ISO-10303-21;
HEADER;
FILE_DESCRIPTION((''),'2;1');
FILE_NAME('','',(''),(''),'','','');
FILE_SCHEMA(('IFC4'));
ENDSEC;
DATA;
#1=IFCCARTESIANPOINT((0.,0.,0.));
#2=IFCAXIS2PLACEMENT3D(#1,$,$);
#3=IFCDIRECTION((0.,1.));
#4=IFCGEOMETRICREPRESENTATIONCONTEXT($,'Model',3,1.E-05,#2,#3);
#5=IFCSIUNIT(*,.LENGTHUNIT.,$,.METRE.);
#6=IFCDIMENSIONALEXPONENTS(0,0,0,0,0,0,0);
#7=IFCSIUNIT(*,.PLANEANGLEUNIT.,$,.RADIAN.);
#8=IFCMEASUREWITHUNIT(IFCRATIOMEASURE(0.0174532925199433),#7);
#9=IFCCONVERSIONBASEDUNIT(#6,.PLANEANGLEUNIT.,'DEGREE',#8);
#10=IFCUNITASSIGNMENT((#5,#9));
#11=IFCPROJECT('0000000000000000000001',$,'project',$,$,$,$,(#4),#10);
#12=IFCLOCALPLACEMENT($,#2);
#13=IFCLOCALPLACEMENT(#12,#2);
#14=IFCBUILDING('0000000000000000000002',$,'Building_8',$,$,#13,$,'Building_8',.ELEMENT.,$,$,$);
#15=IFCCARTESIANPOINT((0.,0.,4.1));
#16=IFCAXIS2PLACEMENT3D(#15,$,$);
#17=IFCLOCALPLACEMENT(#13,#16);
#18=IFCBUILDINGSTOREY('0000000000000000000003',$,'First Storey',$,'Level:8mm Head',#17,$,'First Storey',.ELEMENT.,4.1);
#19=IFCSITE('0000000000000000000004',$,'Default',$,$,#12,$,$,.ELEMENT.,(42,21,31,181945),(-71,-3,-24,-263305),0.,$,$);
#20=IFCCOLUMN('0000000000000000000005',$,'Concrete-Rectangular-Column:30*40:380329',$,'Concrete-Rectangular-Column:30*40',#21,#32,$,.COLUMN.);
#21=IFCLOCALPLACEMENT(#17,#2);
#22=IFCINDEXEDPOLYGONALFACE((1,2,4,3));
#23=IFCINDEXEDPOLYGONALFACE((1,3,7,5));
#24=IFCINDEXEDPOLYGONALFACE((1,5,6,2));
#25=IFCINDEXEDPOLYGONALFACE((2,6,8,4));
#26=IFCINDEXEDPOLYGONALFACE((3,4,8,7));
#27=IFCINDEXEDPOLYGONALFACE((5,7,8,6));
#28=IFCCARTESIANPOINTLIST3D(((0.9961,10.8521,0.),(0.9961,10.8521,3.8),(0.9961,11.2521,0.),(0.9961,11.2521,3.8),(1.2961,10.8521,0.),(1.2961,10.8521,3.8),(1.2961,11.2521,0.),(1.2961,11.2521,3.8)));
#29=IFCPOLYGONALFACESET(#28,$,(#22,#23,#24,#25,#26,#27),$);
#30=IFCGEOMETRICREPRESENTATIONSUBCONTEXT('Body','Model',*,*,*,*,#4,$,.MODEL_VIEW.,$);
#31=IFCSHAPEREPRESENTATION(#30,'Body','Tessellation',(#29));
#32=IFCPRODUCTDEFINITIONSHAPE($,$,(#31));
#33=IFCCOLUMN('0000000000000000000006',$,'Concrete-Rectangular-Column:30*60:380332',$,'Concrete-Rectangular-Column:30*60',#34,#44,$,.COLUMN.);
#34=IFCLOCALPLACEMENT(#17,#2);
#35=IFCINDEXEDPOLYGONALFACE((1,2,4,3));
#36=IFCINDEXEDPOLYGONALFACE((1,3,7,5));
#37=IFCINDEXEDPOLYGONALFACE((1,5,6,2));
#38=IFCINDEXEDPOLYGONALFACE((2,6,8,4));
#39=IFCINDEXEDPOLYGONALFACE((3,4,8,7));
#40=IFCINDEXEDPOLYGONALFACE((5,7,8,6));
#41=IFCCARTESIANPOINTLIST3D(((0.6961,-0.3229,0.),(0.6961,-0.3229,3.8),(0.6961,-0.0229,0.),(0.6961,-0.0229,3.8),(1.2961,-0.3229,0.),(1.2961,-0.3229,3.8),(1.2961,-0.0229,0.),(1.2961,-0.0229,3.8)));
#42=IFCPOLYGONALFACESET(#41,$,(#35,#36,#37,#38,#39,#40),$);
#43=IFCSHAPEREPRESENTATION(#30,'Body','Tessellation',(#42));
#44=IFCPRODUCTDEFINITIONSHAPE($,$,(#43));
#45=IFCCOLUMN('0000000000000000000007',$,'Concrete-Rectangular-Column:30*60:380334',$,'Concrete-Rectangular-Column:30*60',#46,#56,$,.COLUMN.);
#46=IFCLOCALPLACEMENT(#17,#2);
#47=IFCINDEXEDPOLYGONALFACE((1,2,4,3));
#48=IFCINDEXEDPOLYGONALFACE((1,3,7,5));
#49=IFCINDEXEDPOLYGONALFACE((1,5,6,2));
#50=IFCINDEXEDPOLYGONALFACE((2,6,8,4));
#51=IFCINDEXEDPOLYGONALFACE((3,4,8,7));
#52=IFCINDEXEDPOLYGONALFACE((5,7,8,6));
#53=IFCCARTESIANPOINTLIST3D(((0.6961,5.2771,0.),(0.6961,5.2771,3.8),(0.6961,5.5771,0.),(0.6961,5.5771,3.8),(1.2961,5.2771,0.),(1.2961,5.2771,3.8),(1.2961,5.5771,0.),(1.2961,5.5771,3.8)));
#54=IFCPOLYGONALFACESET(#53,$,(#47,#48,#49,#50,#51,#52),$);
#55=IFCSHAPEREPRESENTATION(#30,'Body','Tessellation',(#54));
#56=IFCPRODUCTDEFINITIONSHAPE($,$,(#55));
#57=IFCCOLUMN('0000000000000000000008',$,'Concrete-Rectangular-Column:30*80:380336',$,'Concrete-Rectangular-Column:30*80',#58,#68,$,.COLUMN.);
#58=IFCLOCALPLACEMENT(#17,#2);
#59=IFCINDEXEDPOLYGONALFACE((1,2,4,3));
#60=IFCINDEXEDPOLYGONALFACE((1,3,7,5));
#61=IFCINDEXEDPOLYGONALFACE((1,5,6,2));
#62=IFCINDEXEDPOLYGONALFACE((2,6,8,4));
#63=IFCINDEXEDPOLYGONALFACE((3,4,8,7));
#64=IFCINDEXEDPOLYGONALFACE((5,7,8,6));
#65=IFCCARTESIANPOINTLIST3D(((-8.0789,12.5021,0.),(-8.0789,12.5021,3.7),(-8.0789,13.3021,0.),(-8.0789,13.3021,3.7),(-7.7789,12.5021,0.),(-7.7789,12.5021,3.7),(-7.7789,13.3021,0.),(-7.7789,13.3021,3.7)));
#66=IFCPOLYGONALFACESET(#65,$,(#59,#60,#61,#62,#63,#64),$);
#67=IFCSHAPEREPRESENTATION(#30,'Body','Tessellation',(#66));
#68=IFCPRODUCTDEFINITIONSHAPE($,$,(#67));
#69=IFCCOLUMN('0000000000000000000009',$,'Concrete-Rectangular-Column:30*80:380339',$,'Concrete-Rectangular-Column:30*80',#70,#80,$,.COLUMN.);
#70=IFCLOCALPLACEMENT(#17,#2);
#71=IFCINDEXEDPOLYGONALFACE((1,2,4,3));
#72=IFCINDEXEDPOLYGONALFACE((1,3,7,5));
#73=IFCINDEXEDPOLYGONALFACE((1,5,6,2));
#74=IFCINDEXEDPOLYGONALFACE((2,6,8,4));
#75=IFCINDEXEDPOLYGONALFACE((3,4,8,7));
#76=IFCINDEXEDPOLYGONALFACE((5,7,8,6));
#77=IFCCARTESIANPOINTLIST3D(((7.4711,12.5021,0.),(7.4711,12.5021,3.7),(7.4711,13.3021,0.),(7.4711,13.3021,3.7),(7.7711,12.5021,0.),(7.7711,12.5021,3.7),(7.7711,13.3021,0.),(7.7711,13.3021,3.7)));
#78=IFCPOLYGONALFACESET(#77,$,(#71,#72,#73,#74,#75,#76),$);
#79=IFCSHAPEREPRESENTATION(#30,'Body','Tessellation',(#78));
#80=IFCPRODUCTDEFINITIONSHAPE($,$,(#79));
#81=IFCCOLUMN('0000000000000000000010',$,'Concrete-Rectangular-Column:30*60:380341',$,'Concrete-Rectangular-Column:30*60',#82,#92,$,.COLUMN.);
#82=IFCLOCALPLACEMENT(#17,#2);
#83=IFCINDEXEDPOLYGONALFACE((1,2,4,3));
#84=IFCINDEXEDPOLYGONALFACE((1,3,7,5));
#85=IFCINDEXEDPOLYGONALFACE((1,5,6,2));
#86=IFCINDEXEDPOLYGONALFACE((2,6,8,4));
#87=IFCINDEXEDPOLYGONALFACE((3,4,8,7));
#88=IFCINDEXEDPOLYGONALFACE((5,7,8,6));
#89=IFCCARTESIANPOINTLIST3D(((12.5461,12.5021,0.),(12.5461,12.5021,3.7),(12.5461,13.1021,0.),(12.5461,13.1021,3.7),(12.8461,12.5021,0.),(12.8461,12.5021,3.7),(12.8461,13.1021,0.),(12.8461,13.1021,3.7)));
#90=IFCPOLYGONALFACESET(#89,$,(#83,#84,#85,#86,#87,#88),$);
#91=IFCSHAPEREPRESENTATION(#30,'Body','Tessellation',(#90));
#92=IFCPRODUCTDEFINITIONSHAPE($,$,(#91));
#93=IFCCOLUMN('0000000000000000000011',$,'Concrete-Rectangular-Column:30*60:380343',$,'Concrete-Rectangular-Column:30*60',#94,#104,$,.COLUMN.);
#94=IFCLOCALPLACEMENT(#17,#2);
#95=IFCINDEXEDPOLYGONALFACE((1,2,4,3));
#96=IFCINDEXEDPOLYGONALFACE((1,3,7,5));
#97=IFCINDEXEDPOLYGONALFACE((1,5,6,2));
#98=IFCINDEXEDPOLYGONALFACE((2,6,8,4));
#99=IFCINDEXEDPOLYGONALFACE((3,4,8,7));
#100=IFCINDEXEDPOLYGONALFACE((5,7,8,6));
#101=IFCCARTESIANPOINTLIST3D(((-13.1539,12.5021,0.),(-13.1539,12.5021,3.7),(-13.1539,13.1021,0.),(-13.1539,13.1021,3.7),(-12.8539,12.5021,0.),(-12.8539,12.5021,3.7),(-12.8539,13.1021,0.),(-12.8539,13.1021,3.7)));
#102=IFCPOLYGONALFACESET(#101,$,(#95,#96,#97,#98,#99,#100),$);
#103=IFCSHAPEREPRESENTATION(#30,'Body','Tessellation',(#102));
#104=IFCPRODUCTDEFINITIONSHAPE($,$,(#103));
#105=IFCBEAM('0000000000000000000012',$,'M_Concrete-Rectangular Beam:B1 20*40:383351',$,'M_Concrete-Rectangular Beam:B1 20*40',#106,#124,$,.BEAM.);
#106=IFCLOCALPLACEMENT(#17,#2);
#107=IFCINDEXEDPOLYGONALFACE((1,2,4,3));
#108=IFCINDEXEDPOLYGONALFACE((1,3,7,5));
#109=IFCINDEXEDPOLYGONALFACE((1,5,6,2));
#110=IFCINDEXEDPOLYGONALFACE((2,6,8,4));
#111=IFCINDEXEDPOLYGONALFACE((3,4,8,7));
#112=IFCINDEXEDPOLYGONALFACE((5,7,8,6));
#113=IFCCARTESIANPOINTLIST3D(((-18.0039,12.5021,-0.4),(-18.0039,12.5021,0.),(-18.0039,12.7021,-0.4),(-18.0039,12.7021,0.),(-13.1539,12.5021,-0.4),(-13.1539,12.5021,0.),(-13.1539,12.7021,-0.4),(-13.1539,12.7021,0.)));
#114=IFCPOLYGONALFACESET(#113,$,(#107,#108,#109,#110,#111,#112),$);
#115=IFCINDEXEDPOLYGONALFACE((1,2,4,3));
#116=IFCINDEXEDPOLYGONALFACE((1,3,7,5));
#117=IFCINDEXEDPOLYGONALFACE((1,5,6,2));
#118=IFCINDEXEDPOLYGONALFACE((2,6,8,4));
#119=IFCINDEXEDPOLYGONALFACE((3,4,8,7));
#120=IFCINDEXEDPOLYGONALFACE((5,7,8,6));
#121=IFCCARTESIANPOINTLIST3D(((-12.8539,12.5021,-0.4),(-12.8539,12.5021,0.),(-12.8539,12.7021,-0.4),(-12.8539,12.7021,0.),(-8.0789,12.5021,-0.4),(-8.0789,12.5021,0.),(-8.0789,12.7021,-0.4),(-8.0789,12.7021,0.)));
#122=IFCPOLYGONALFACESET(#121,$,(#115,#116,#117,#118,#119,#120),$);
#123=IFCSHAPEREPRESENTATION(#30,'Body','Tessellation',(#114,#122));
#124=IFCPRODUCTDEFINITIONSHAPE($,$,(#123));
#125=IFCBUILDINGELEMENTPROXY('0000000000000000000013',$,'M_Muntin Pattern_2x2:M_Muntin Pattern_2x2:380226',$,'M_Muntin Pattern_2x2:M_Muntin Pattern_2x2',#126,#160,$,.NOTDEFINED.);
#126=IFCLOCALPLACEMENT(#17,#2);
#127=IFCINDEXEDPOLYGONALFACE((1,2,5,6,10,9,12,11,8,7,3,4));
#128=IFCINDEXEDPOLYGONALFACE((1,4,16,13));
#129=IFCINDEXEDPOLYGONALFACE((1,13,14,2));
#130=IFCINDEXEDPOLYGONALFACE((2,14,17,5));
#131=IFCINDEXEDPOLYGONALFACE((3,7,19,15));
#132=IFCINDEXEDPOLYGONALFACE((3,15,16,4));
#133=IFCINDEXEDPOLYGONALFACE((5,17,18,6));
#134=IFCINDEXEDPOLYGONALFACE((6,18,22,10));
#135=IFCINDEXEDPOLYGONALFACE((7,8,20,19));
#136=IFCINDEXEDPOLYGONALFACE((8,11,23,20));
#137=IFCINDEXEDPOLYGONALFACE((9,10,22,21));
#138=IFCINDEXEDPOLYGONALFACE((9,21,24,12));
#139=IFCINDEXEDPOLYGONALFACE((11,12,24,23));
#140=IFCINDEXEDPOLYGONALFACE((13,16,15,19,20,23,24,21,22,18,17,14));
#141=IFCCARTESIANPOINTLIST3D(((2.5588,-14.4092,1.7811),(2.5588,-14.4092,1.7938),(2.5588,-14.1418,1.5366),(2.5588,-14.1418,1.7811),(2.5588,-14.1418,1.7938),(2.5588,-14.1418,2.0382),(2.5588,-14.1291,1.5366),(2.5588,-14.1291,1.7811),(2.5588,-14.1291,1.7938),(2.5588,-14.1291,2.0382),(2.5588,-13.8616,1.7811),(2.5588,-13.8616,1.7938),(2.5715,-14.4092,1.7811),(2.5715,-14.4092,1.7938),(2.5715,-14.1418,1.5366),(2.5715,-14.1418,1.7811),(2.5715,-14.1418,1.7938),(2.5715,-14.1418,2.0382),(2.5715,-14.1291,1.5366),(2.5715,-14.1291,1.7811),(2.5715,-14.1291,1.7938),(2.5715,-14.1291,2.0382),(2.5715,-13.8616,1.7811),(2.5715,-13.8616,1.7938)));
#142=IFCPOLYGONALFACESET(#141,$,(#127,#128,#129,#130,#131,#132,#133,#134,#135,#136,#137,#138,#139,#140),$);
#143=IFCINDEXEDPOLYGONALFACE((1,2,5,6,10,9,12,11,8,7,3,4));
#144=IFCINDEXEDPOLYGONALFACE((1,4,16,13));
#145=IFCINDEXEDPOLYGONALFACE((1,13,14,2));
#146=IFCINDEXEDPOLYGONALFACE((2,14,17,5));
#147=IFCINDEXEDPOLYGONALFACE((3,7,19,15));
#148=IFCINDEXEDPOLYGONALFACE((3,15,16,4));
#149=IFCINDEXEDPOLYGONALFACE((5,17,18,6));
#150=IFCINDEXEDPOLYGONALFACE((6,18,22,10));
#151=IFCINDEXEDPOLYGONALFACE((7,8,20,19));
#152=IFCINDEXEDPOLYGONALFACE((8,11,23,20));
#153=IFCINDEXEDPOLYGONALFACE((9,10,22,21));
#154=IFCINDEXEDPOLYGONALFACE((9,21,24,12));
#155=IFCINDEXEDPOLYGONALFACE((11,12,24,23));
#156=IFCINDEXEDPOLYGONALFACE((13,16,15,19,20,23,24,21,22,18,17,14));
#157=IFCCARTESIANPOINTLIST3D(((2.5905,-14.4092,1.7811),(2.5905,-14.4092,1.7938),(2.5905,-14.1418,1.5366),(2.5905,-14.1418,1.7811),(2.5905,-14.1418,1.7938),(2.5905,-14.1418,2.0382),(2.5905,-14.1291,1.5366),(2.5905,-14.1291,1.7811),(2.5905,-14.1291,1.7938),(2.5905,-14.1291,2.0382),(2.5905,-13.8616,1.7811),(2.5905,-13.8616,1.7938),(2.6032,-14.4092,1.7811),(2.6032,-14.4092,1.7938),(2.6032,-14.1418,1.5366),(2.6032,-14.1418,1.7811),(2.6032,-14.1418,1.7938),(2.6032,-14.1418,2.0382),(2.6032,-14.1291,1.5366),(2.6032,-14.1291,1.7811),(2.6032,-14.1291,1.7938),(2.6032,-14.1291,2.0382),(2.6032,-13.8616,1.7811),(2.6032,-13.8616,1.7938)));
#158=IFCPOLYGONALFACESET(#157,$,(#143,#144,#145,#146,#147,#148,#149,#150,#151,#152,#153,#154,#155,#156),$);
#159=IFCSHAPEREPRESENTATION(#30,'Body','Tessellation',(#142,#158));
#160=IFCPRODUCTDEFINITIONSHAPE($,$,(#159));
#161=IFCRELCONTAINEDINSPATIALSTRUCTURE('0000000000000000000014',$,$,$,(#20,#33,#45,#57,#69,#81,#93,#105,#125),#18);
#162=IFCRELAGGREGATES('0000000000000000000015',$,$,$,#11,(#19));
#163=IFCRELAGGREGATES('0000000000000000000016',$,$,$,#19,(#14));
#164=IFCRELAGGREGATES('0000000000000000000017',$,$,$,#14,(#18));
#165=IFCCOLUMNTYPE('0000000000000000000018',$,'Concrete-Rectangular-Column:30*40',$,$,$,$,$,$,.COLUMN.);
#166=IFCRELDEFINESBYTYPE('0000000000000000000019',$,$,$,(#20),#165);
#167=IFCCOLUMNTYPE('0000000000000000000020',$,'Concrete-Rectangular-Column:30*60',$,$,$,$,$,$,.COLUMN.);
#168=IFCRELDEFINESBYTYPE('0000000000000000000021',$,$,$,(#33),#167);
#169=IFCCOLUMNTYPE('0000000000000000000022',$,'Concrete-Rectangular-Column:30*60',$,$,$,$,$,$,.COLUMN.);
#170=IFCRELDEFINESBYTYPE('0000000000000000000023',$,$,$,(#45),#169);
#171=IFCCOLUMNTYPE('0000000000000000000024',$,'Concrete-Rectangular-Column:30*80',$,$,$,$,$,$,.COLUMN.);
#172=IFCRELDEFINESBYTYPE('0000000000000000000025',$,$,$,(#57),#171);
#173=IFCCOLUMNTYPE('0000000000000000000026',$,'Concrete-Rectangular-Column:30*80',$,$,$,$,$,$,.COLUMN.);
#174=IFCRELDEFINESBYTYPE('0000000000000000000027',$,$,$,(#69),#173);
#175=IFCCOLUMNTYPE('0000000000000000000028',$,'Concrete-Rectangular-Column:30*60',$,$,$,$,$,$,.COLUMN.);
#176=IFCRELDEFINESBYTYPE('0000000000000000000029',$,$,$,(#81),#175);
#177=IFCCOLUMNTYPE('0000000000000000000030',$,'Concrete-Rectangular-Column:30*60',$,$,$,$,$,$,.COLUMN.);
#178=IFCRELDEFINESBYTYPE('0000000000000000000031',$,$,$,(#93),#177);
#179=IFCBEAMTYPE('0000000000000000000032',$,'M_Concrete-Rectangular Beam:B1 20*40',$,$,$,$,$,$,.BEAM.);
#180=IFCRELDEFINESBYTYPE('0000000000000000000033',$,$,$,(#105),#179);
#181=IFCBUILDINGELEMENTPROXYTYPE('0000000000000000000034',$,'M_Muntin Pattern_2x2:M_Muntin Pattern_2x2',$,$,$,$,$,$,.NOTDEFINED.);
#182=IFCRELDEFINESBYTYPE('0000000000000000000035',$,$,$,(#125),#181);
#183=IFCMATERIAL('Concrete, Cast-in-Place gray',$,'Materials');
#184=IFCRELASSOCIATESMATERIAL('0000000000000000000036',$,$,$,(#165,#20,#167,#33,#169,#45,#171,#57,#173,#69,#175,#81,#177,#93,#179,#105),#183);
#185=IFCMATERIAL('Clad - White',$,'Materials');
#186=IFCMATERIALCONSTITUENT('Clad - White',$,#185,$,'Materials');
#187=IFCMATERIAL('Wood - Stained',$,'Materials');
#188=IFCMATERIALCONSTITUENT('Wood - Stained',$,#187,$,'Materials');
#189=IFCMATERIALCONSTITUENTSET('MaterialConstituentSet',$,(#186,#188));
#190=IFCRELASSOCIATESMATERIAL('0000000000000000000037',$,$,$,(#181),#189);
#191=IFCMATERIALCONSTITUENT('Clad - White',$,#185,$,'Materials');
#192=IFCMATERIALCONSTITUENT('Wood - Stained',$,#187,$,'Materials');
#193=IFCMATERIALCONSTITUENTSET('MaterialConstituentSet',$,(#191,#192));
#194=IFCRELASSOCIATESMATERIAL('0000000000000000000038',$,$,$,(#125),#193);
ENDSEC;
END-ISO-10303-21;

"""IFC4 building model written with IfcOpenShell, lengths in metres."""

from ifc_helpers import new_model, entity, si_unit, converted_unit, direction, frame, origin, place, context, subcontext, project, spatial, indexed_curve, outline, extrude, source, transform, mapped, material, constituent, constituent_set, type_object, type_shapes, element, save


model = new_model("IFC4")

# Units and contexts
model_context = context("Model", 3, precision=1e-05, world=origin(), true_north=direction((0.0, 1.0)))
body_context = subcontext(model_context, "Body", "Model", "MODEL_VIEW")
ifc_project = project(units=[si_unit("LENGTHUNIT", "METRE"), converted_unit("PLANEANGLEUNIT", "DEGREE", entity("IfcRatioMeasure", 0.0174532925199433), si_unit("PLANEANGLEUNIT", "RADIAN"), dimensions=[0, 0, 0, 0, 0, 0, 0])], contexts=[model_context])

# Site, building, storey
site_placement = place(None, origin())
site = spatial("IfcSite", under=ifc_project, at=site_placement, Name="Default", CompositionType="ELEMENT", RefLatitude=(42, 21, 31, 181945), RefLongitude=(-71, -3, -24, -263305), RefElevation=0.0)
building_placement = place(site_placement, origin())
building = spatial("IfcBuilding", under=site, at=building_placement, Name="Building_8", LongName="Building_8", CompositionType="ELEMENT")
storey_placement = place(building_placement, frame((0.0, 0.0, 4.1)))
storey = spatial("IfcBuildingStorey", under=building, at=storey_placement, Name="First Storey", ObjectType="Level:8mm Head", LongName="First Storey", CompositionType="ELEMENT", Elevation=4.1)

# Columns
ifc_material_1 = material(Name="Concrete, Cast-in-Place gray", Category="Materials")
column_type_1 = type_object("IfcColumnType", Name="Concrete-Rectangular-Column:30*40", PredefinedType="COLUMN", material=ifc_material_1)
shared_shape_1 = source(origin(), body_context, "Body", "SweptSolid", [
    extrude(outline(indexed_curve([(-0.2, -0.15), (0.2, -0.15), (0.2, 0.15), (-0.2, 0.15), (-0.2, -0.15)], self_intersect=False)), frame((1.1461, 11.0521, 4.1), z_axis=(0.0, 0.0, 1.0), x_axis=(0.0, -1.0, 0.0)), (0.0, 0.0, 1.0), 3.8),
])
type_shapes(column_type_1, [shared_shape_1])
column_1_placement = place(storey_placement, frame((0.0, 0.0, -4.1)))
element("IfcColumn", 1, at=column_1_placement, inside=storey, type_object=column_type_1, material=ifc_material_1, Name="Concrete-Rectangular-Column:30*40:380329", ObjectType="Concrete-Rectangular-Column:30*40", PredefinedType="COLUMN", context=body_context, shape_type="MappedRepresentation", body=[
    mapped(shared_shape_1, transform((0.0, 0.0, 0.0), scale=1.0)),
])
column_type_2 = type_object("IfcColumnType", Name="Concrete-Rectangular-Column:30*60", PredefinedType="COLUMN", material=ifc_material_1)
shared_shape_2 = source(origin(), body_context, "Body", "SweptSolid", [
    extrude(outline(indexed_curve([(-0.15, -0.3), (0.15, -0.3), (0.15, 0.3), (-0.15, 0.3), (-0.15, -0.3)], self_intersect=False)), frame((0.9961, -0.1729, 4.1), z_axis=(0.0, 0.0, 1.0), x_axis=(0.0, -1.0, 0.0)), (0.0, 0.0, 1.0), 3.8),
])
type_shapes(column_type_2, [shared_shape_2])
column_2_placement = place(storey_placement, frame((0.0, 0.0, -4.1)))
element("IfcColumn", 2, at=column_2_placement, inside=storey, type_object=column_type_2, material=ifc_material_1, Name="Concrete-Rectangular-Column:30*60:380332", ObjectType="Concrete-Rectangular-Column:30*60", PredefinedType="COLUMN", context=body_context, shape_type="MappedRepresentation", body=[
    mapped(shared_shape_2, transform((0.0, 0.0, 0.0), scale=1.0)),
])
column_type_3 = type_object("IfcColumnType", Name="Concrete-Rectangular-Column:30*60", PredefinedType="COLUMN", material=ifc_material_1)
shared_shape_3 = source(origin(), body_context, "Body", "SweptSolid", [
    extrude(outline(indexed_curve([(-0.15, -0.3), (0.15, -0.3), (0.15, 0.3), (-0.15, 0.3), (-0.15, -0.3)], self_intersect=False)), frame((0.9961, 5.4271, 4.1), z_axis=(0.0, 0.0, 1.0), x_axis=(0.0, -1.0, 0.0)), (0.0, 0.0, 1.0), 3.8),
])
type_shapes(column_type_3, [shared_shape_3])
column_3_placement = place(storey_placement, frame((0.0, 0.0, -4.1)))
element("IfcColumn", 3, at=column_3_placement, inside=storey, type_object=column_type_3, material=ifc_material_1, Name="Concrete-Rectangular-Column:30*60:380334", ObjectType="Concrete-Rectangular-Column:30*60", PredefinedType="COLUMN", context=body_context, shape_type="MappedRepresentation", body=[
    mapped(shared_shape_3, transform((0.0, 0.0, 0.0), scale=1.0)),
])
column_type_4 = type_object("IfcColumnType", Name="Concrete-Rectangular-Column:30*80", PredefinedType="COLUMN", material=ifc_material_1)
shared_shape_4 = source(origin(), body_context, "Body", "SweptSolid", [
    extrude(outline(indexed_curve([(-0.4, -0.15), (0.4, -0.15), (0.4, 0.15), (-0.4, 0.15), (-0.4, -0.15)], self_intersect=False)), frame((-7.9289, 12.9021, 4.1), z_axis=(0.0, 0.0, 1.0), x_axis=(0.0, -1.0, 0.0)), (0.0, 0.0, 1.0), 3.7),
])
type_shapes(column_type_4, [shared_shape_4])
column_4_placement = place(storey_placement, frame((0.0, 0.0, -4.1)))
element("IfcColumn", 4, at=column_4_placement, inside=storey, type_object=column_type_4, material=ifc_material_1, Name="Concrete-Rectangular-Column:30*80:380336", ObjectType="Concrete-Rectangular-Column:30*80", PredefinedType="COLUMN", context=body_context, shape_type="MappedRepresentation", body=[
    mapped(shared_shape_4, transform((0.0, 0.0, 0.0), scale=1.0)),
])
column_type_5 = type_object("IfcColumnType", Name="Concrete-Rectangular-Column:30*80", PredefinedType="COLUMN", material=ifc_material_1)
shared_shape_5 = source(origin(), body_context, "Body", "SweptSolid", [
    extrude(outline(indexed_curve([(-0.4, -0.15), (0.4, -0.15), (0.4, 0.15), (-0.4, 0.15), (-0.4, -0.15)], self_intersect=False)), frame((7.6211, 12.9021, 4.1), z_axis=(0.0, 0.0, 1.0), x_axis=(0.0, -1.0, 0.0)), (0.0, 0.0, 1.0), 3.7),
])
type_shapes(column_type_5, [shared_shape_5])
column_5_placement = place(storey_placement, frame((0.0, 0.0, -4.1)))
element("IfcColumn", 5, at=column_5_placement, inside=storey, type_object=column_type_5, material=ifc_material_1, Name="Concrete-Rectangular-Column:30*80:380339", ObjectType="Concrete-Rectangular-Column:30*80", PredefinedType="COLUMN", context=body_context, shape_type="MappedRepresentation", body=[
    mapped(shared_shape_5, transform((0.0, 0.0, 0.0), scale=1.0)),
])
column_type_6 = type_object("IfcColumnType", Name="Concrete-Rectangular-Column:30*60", PredefinedType="COLUMN", material=ifc_material_1)
shared_shape_6 = source(origin(), body_context, "Body", "SweptSolid", [
    extrude(outline(indexed_curve([(-0.3, -0.15), (0.3, -0.15), (0.3, 0.15), (-0.3, 0.15), (-0.3, -0.15)], self_intersect=False)), frame((12.6961, 12.8021, 4.1), z_axis=(0.0, 0.0, 1.0), x_axis=(0.0, -1.0, 0.0)), (0.0, 0.0, 1.0), 3.7),
])
type_shapes(column_type_6, [shared_shape_6])
column_6_placement = place(storey_placement, frame((0.0, 0.0, -4.1)))
element("IfcColumn", 6, at=column_6_placement, inside=storey, type_object=column_type_6, material=ifc_material_1, Name="Concrete-Rectangular-Column:30*60:380341", ObjectType="Concrete-Rectangular-Column:30*60", PredefinedType="COLUMN", context=body_context, shape_type="MappedRepresentation", body=[
    mapped(shared_shape_6, transform((0.0, 0.0, 0.0), scale=1.0)),
])
column_type_7 = type_object("IfcColumnType", Name="Concrete-Rectangular-Column:30*60", PredefinedType="COLUMN", material=ifc_material_1)
shared_shape_7 = source(origin(), body_context, "Body", "SweptSolid", [
    extrude(outline(indexed_curve([(-0.3, -0.15), (0.3, -0.15), (0.3, 0.15), (-0.3, 0.15), (-0.3, -0.15)], self_intersect=False)), frame((-13.0039, 12.8021, 4.1), z_axis=(0.0, 0.0, 1.0), x_axis=(0.0, -1.0, 0.0)), (0.0, 0.0, 1.0), 3.7),
])
type_shapes(column_type_7, [shared_shape_7])
column_7_placement = place(storey_placement, frame((0.0, 0.0, -4.1)))
element("IfcColumn", 7, at=column_7_placement, inside=storey, type_object=column_type_7, material=ifc_material_1, Name="Concrete-Rectangular-Column:30*60:380343", ObjectType="Concrete-Rectangular-Column:30*60", PredefinedType="COLUMN", context=body_context, shape_type="MappedRepresentation", body=[
    mapped(shared_shape_7, transform((0.0, 0.0, 0.0), scale=1.0)),
])

# Beam
beam_type = type_object("IfcBeamType", Name="M_Concrete-Rectangular Beam:B1 20*40", PredefinedType="BEAM", material=ifc_material_1)
shared_shape_8 = source(origin(), body_context, "Body", "SweptSolid", [
    extrude(outline(indexed_curve([(-0.2, -0.1), (0.2, -0.1), (0.2, 0.1), (-0.2, 0.1), (-0.2, -0.1)], self_intersect=False)), frame((-18.0039, 12.6021, 3.9), z_axis=(1.0, 0.0, 0.0), x_axis=(0.0, 0.0, -1.0)), (0.0, 0.0, 1.0), 4.85),
    extrude(outline(indexed_curve([(-0.2, -0.1), (0.2, -0.1), (0.2, 0.1), (-0.2, 0.1), (-0.2, -0.1)], self_intersect=False)), frame((-12.8539, 12.6021, 3.9), z_axis=(1.0, 0.0, 0.0), x_axis=(0.0, 0.0, -1.0)), (0.0, 0.0, 1.0), 4.775),
])
type_shapes(beam_type, [shared_shape_8])
beam_placement = place(storey_placement, frame((0.0, 0.0, -4.1)))
element("IfcBeam", 8, at=beam_placement, inside=storey, type_object=beam_type, material=ifc_material_1, Name="M_Concrete-Rectangular Beam:B1 20*40:383351", ObjectType="M_Concrete-Rectangular Beam:B1 20*40", PredefinedType="BEAM", context=body_context, shape_type="MappedRepresentation", body=[
    mapped(shared_shape_8, transform((0.0, 0.0, 0.0), scale=1.0)),
])

# Building element proxy
ifc_material_2 = material(Name="Clad - White", Category="Materials")
ifc_constituent_1 = constituent(ifc_material_2, Name="Clad - White", Category="Materials")
ifc_material_3 = material(Name="Wood - Stained", Category="Materials")
ifc_constituent_2 = constituent(ifc_material_3, Name="Wood - Stained", Category="Materials")
ifc_constituent_set_1 = constituent_set(constituents=[ifc_constituent_1, ifc_constituent_2], Name="MaterialConstituentSet")
ifc_constituent_3 = constituent(ifc_material_2, Name="Clad - White", Category="Materials")
ifc_constituent_4 = constituent(ifc_material_3, Name="Wood - Stained", Category="Materials")
ifc_constituent_set_2 = constituent_set(constituents=[ifc_constituent_3, ifc_constituent_4], Name="MaterialConstituentSet")
building_element_proxy_type_1 = type_object("IfcBuildingElementProxyType", Name="M_Muntin Pattern_2x2:M_Muntin Pattern_2x2", PredefinedType="NOTDEFINED", material=ifc_constituent_set_2)
shared_shape_9 = source(origin(), body_context, "Body", "SweptSolid", [
    extrude(outline(indexed_curve([(0.0064, -0.0064), (0.2508, -0.0064), (0.2508, 0.0063), (0.0064, 0.0063), (0.0064, 0.2738), (-0.0063, 0.2738), (-0.0063, 0.0063), (-0.2508, 0.0063), (-0.2508, -0.0064), (-0.0063, -0.0064), (-0.0063, -0.2738), (0.0064, -0.2738), (0.0064, -0.0064)], self_intersect=False)), frame((0.0, 0.0095, 0.2508), z_axis=(0.0, 1.0, 0.0), x_axis=(0.0, 0.0, 1.0)), (0.0, 0.0, 1.0), 0.0127),
    extrude(outline(indexed_curve([(0.0064, -0.0064), (0.2508, -0.0064), (0.2508, 0.0063), (0.0064, 0.0063), (0.0064, 0.2738), (-0.0063, 0.2738), (-0.0063, 0.0063), (-0.2508, 0.0063), (-0.2508, -0.0064), (-0.0063, -0.0064), (-0.0063, -0.2738), (0.0064, -0.2738), (0.0064, -0.0064)], self_intersect=False)), frame((0.0, -0.0222, 0.2508), z_axis=(0.0, 1.0, 0.0), x_axis=(0.0, 0.0, 1.0)), (0.0, 0.0, 1.0), 0.0127),
])
type_shapes(building_element_proxy_type_1, [shared_shape_9])
proxy_1_placement = place(storey_placement, frame((2.581, -14.1354, 1.5366), z_axis=(0.0, 0.0, 1.0), x_axis=(0.0, 1.0, 0.0)))
element("IfcBuildingElementProxy", 9, at=proxy_1_placement, inside=storey, type_object=building_element_proxy_type_1, material=ifc_constituent_set_1, Name="M_Muntin Pattern_2x2:M_Muntin Pattern_2x2:380226", ObjectType="M_Muntin Pattern_2x2:M_Muntin Pattern_2x2", PredefinedType="NOTDEFINED", context=body_context, shape_type="MappedRepresentation", body=[
    mapped(shared_shape_9, transform((0.0, 0.0, 0.0), scale=1.0)),
])

save(model, "model.ifc")
